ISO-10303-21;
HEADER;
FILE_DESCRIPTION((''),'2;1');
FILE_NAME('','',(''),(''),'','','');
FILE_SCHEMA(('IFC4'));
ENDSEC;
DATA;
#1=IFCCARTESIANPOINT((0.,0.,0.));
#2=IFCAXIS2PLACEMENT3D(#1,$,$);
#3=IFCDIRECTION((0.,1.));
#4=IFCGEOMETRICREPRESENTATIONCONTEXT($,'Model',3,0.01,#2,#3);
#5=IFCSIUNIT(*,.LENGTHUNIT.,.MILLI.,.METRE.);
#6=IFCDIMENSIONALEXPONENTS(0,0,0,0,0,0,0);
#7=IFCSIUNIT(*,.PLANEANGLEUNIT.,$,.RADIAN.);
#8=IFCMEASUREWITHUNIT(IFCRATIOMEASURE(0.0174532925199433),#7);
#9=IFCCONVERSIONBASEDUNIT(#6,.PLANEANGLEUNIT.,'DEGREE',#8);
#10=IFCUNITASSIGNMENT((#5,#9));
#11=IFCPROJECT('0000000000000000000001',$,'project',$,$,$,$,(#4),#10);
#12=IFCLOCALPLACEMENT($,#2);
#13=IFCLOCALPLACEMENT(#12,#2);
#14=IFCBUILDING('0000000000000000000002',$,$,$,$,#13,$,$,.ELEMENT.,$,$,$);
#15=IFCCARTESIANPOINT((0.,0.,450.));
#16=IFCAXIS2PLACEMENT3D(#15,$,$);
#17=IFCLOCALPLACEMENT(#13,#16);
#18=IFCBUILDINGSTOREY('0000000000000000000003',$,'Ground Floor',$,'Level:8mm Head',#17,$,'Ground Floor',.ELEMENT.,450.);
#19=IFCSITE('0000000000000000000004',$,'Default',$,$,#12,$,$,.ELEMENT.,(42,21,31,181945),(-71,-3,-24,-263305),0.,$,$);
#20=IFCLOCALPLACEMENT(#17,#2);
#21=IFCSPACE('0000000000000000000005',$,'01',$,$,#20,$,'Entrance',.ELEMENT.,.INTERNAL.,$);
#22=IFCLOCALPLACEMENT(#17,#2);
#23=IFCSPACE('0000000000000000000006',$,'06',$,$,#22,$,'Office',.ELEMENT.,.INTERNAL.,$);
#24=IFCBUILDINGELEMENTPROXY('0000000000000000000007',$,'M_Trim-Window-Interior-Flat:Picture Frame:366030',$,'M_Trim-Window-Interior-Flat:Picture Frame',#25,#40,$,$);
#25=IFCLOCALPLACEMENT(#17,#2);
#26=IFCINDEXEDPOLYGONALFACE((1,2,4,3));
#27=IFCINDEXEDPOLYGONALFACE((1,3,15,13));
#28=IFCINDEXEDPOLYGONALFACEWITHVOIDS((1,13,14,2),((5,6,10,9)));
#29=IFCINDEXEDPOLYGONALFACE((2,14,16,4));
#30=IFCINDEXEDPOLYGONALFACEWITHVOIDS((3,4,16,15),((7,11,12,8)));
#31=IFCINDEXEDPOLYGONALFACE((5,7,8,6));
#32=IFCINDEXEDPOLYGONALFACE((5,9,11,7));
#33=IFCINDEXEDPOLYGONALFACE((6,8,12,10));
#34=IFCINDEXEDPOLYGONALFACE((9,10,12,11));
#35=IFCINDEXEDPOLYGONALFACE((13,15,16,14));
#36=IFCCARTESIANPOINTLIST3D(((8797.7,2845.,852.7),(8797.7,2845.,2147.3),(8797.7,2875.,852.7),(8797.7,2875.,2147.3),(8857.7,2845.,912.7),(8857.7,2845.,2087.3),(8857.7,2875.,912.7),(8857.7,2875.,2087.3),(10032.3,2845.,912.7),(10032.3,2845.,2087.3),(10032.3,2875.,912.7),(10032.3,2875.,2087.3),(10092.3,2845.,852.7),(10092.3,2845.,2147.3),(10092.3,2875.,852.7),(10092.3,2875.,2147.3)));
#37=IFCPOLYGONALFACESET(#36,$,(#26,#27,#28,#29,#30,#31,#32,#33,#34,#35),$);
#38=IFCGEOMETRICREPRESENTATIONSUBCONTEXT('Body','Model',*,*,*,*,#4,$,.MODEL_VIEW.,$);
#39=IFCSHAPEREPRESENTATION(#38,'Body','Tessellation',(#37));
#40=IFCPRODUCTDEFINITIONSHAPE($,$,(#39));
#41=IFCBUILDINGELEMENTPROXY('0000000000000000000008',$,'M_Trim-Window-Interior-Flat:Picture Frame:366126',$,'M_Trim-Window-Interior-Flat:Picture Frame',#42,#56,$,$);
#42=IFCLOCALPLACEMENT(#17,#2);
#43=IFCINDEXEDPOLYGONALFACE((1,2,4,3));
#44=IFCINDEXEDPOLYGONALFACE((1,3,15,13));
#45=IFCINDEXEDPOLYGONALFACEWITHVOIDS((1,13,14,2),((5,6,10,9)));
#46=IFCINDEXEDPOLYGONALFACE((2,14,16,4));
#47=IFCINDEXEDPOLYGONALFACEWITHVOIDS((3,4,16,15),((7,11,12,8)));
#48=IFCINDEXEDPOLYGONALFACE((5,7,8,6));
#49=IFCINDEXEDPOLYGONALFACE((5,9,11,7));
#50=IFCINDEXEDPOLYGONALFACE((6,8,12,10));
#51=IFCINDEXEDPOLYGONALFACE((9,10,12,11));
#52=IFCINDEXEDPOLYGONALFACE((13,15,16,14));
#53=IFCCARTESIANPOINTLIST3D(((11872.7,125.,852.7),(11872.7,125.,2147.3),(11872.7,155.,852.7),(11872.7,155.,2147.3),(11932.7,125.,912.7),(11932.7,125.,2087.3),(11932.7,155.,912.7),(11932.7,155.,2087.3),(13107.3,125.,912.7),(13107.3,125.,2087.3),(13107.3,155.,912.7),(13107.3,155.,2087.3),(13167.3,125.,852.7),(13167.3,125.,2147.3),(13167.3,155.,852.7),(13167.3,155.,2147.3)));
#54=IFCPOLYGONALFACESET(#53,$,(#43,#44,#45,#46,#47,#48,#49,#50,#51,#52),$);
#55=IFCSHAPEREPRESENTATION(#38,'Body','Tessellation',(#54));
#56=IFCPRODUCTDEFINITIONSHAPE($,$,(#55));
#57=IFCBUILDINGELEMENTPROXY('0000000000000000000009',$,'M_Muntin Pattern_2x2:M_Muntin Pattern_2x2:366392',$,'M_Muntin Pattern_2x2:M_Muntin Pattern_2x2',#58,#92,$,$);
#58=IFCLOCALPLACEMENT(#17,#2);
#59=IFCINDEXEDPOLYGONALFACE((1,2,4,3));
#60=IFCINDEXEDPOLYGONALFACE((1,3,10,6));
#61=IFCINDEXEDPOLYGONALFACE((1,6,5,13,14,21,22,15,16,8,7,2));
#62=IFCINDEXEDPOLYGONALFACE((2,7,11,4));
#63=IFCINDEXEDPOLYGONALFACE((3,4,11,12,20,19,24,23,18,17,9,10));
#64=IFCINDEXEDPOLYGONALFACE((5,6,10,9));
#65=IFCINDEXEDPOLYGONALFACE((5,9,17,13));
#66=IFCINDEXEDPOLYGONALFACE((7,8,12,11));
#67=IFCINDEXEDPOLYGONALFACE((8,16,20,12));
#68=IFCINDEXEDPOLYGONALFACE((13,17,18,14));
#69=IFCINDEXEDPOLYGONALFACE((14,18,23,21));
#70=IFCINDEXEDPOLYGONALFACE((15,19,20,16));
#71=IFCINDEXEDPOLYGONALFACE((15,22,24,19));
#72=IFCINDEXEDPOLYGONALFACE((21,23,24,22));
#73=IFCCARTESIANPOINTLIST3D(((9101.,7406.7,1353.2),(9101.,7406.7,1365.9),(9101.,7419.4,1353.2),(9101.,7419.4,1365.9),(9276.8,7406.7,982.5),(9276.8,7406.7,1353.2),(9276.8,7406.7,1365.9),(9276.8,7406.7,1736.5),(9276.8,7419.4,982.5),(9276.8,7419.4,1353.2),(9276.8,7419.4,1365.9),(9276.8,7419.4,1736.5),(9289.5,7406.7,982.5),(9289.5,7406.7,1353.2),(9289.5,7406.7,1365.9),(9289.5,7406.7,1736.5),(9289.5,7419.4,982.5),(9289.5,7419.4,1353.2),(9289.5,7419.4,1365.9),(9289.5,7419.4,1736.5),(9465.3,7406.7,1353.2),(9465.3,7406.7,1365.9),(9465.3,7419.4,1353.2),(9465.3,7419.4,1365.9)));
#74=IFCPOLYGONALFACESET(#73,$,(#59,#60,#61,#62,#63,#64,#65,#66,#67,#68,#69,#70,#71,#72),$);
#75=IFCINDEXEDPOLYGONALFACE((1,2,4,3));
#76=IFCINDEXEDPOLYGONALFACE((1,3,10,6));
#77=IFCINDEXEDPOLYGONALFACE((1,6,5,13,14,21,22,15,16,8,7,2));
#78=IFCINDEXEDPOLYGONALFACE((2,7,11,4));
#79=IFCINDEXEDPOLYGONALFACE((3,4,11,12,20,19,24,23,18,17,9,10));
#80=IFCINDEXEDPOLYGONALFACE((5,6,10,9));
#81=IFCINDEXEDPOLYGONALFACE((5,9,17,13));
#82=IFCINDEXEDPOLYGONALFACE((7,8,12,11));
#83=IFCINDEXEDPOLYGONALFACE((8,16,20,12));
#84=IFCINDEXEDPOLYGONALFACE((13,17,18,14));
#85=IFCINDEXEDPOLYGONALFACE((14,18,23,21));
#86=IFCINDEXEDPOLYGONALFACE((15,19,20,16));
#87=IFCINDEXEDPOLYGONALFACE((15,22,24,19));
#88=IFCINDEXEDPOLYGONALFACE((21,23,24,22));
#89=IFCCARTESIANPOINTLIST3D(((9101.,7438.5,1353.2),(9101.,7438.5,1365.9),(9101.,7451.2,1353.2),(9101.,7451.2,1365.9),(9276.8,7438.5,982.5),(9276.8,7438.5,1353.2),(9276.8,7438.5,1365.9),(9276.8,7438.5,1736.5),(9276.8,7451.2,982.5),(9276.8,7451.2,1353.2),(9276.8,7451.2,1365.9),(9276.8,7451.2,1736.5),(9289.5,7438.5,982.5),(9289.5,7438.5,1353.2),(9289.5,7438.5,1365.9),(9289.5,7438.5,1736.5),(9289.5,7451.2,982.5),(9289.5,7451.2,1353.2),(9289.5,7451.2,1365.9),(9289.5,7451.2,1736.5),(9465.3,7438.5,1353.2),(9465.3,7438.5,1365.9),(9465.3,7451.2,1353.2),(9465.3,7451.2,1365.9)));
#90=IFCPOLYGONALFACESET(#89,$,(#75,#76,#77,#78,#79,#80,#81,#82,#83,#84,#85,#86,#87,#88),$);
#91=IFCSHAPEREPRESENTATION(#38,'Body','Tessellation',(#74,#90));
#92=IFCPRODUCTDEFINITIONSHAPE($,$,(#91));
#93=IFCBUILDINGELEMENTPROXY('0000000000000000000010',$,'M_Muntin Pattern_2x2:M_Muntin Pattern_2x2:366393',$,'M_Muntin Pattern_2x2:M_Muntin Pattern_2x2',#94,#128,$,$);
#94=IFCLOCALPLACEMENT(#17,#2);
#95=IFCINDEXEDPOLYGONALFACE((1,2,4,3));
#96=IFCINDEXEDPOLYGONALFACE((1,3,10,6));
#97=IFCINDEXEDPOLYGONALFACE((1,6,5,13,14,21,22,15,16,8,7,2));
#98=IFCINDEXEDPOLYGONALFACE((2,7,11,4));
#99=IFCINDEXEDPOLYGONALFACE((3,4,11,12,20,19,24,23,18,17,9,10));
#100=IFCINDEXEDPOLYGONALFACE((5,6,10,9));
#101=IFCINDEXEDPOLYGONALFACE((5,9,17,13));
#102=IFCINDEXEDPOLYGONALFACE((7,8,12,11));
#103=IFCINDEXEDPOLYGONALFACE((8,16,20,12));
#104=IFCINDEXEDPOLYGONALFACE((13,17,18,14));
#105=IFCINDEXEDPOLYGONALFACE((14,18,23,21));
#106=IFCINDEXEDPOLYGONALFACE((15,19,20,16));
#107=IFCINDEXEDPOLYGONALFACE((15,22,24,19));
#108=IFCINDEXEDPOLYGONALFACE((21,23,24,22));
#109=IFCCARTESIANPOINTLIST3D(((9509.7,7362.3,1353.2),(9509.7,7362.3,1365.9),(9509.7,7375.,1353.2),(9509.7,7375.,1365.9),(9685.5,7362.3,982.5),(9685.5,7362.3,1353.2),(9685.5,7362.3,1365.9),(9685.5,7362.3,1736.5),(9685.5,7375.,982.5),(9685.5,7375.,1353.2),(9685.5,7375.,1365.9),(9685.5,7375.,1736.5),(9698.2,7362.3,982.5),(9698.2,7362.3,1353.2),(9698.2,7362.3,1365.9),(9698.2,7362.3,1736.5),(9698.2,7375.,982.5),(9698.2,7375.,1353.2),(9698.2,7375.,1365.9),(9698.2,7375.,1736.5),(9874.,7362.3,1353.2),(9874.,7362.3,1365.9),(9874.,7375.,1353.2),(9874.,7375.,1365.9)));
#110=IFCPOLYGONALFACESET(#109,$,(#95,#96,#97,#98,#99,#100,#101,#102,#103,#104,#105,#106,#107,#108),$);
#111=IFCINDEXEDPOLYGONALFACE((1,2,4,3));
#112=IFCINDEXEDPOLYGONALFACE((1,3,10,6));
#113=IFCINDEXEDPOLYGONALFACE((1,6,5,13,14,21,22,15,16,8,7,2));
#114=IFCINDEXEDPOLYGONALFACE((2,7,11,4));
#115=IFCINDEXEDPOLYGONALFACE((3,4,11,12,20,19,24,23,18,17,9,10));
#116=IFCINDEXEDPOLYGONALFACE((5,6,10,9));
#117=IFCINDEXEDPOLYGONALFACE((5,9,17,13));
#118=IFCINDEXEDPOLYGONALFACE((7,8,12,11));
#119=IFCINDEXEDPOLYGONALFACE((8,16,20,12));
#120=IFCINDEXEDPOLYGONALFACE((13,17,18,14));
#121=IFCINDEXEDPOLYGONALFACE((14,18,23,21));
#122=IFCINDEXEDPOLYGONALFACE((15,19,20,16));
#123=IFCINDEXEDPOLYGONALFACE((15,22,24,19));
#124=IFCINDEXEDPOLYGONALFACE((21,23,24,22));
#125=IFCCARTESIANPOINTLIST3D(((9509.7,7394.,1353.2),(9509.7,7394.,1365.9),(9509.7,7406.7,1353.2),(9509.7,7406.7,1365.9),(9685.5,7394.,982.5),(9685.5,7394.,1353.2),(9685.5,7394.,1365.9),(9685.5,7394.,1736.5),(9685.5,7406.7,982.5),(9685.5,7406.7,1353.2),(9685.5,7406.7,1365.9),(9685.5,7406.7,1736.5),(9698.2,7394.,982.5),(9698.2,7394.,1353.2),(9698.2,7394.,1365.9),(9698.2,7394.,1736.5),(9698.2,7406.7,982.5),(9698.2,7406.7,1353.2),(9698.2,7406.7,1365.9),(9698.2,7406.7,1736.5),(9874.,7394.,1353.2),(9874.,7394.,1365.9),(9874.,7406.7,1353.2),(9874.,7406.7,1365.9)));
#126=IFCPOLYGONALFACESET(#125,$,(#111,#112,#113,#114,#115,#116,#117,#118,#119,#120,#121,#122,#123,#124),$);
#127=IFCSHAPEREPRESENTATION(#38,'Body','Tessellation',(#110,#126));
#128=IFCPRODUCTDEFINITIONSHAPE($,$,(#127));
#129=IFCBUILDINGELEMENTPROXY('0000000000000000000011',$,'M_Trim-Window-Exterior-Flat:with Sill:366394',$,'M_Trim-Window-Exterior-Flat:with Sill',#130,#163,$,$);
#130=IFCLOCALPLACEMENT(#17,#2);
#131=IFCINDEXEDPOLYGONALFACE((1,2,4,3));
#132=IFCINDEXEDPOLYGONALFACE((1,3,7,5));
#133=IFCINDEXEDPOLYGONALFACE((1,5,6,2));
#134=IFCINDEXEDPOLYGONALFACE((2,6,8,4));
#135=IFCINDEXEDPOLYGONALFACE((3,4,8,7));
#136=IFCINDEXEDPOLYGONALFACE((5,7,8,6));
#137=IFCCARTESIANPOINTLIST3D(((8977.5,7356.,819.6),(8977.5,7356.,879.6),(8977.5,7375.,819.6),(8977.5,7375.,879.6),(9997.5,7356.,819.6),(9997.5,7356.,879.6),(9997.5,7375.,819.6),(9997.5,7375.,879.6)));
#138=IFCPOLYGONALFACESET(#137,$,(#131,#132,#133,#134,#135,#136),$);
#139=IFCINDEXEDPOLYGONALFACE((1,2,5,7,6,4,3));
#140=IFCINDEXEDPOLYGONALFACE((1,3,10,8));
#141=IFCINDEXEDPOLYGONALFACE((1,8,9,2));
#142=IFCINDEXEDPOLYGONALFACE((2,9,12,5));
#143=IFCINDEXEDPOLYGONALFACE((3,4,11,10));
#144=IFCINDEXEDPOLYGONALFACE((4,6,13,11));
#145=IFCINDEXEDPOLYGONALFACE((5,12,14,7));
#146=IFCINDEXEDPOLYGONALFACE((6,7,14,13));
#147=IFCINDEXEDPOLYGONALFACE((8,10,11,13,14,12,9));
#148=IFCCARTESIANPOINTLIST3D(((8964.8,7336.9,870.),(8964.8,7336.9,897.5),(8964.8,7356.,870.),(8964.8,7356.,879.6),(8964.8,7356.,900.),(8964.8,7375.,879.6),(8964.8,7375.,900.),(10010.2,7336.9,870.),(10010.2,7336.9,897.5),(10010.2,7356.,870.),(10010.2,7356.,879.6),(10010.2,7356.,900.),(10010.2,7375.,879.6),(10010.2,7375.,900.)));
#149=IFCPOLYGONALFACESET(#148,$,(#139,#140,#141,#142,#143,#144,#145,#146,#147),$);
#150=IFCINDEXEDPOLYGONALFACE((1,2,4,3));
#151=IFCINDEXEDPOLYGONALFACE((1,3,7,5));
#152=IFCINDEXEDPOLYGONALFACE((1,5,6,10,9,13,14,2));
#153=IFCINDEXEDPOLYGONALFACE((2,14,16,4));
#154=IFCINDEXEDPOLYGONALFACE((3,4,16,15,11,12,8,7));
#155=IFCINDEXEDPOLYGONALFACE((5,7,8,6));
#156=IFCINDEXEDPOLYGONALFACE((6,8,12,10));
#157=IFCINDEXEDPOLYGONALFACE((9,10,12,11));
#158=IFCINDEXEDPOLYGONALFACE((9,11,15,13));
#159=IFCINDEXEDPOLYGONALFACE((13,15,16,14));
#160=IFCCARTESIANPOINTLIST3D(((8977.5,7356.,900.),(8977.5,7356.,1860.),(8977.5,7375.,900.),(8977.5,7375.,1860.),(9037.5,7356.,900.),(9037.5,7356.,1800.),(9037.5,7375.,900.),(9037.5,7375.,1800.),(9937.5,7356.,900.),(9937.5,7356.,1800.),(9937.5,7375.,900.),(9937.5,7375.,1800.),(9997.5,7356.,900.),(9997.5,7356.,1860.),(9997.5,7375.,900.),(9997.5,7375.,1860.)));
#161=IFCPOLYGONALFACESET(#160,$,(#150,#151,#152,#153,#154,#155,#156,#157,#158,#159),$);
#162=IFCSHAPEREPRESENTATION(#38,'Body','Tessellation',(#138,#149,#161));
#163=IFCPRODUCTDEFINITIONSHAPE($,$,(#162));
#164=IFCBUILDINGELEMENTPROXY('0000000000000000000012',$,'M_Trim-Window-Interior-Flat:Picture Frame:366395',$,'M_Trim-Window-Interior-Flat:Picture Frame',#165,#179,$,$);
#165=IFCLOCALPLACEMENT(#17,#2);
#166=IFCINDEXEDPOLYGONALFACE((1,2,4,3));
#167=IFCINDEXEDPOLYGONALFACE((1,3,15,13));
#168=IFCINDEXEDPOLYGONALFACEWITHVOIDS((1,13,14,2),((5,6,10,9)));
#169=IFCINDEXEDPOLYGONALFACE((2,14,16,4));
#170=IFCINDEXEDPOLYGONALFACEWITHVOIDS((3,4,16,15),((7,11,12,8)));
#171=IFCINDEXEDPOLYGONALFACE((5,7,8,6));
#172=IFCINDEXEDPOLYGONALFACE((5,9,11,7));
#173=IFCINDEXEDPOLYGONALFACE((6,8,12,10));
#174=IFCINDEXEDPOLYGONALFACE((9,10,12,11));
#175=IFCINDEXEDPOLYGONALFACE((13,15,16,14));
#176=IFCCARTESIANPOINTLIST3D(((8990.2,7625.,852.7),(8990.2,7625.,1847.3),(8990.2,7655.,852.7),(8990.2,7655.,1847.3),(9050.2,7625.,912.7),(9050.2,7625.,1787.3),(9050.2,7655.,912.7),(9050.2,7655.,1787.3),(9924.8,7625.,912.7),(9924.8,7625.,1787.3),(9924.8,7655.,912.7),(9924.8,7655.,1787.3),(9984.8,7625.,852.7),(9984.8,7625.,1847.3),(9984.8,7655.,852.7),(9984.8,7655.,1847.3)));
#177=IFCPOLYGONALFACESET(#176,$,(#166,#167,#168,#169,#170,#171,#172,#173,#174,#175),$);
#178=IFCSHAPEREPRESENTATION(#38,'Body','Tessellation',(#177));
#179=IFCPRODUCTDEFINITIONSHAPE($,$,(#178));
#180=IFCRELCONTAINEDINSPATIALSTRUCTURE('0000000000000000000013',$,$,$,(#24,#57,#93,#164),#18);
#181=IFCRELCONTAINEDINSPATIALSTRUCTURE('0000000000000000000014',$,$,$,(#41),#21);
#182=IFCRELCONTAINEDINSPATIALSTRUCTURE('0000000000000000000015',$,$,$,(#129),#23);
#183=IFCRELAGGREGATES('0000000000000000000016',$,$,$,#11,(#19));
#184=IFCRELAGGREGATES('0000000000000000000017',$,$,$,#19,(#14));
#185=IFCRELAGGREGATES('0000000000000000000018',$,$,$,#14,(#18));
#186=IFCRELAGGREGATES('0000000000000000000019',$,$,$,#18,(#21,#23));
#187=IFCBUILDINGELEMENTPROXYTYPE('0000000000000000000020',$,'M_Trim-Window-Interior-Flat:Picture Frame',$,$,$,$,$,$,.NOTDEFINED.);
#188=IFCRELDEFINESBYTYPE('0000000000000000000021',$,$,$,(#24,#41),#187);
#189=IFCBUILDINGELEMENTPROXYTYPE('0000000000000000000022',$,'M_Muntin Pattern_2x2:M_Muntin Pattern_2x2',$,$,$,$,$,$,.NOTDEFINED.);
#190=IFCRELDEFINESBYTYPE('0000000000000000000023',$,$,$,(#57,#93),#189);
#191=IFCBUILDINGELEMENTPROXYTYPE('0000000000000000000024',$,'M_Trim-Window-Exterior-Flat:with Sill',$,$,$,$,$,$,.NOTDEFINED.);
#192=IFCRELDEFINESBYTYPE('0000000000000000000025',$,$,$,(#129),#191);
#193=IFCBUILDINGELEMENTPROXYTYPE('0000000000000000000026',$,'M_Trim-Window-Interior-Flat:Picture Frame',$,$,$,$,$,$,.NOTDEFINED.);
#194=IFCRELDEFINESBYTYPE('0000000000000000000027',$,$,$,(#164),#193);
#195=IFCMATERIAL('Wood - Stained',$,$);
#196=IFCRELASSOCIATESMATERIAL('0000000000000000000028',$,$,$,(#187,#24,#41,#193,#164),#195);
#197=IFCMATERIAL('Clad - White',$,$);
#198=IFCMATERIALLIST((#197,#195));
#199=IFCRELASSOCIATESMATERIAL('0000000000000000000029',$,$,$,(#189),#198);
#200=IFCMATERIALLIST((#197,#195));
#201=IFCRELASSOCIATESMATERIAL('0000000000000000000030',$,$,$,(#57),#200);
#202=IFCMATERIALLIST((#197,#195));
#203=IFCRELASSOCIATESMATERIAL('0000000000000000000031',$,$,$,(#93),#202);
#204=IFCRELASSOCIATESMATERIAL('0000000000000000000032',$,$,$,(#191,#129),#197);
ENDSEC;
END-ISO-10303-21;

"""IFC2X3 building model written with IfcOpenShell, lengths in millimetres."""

from ifc_helpers import new_model, entity, si_unit, converted_unit, direction, frame, frame_2d, origin, place, context, subcontext, project, spatial, polyline, rectangle, outline, extrude, source, transform, mapped, material, material_list, type_object, type_shapes, element, save


model = new_model("IFC2X3")

# Units and contexts
model_context = context("Model", 3, precision=0.01, world=origin(), true_north=direction((0.0, 1.0)))
body_context = subcontext(model_context, "Body", "Model", "MODEL_VIEW")
ifc_project = project(units=[si_unit("LENGTHUNIT", "METRE", prefix="MILLI"), converted_unit("PLANEANGLEUNIT", "DEGREE", entity("IfcRatioMeasure", 0.0174532925199433), si_unit("PLANEANGLEUNIT", "RADIAN"), dimensions=[0, 0, 0, 0, 0, 0, 0])], contexts=[model_context])

# Site, building, storey
site_placement = place(None, origin())
site = spatial("IfcSite", under=ifc_project, at=site_placement, Name="Default", CompositionType="ELEMENT", RefLatitude=(42, 21, 31, 181945), RefLongitude=(-71, -3, -24, -263305), RefElevation=0.0)
building_placement = place(site_placement, origin())
building = spatial("IfcBuilding", under=site, at=building_placement, CompositionType="ELEMENT")
storey_placement = place(building_placement, frame((0.0, 0.0, 450.0)))
storey = spatial("IfcBuildingStorey", under=building, at=storey_placement, Name="Ground Floor", ObjectType="Level:8mm Head", LongName="Ground Floor", CompositionType="ELEMENT", Elevation=450.0)

# Shared definitions
ifc_material_1 = material(Name="Clad - White")
ifc_material_2 = material(Name="Wood - Stained")

# Building element proxy
building_element_proxy_type_1 = type_object("IfcBuildingElementProxyType", Name="M_Trim-Window-Interior-Flat:Picture Frame", PredefinedType="NOTDEFINED", material=ifc_material_2)
shared_shape_1 = source(origin(), body_context, "Body", "SweptSolid", [
    extrude(outline(polyline([(-647.3, -647.3), (647.3, -647.3), (647.3, 647.3), (-647.3, 647.3), (-647.3, -647.3)]), holes=[polyline([(-587.3, -587.3), (-587.3, 587.3), (587.3, 587.3), (587.3, -587.3), (-587.3, -587.3)])]), frame((0.0, -600.0, 0.0), z_axis=(0.0, 0.0, 1.0), x_axis=(-1.0, 0.0, 0.0)), (0.0, 0.0, 1.0), 30.0),
])
type_shapes(building_element_proxy_type_1, [shared_shape_1])
proxy_1_placement = place(storey_placement, frame((9445.0, 2875.0, 2100.0), z_axis=(0.0, -1.0, 0.0), x_axis=(1.0, 0.0, 0.0)))
element("IfcBuildingElementProxy", 1, at=proxy_1_placement, inside=storey, type_object=building_element_proxy_type_1, material=ifc_material_2, Name="M_Trim-Window-Interior-Flat:Picture Frame:366030", ObjectType="M_Trim-Window-Interior-Flat:Picture Frame", context=body_context, shape_type="MappedRepresentation", body=[
    mapped(shared_shape_1, transform((0.0, 0.0, 0.0), scale=1.0)),
])

# Shared definitions
space_1_placement = place(storey_placement, origin())
space_1 = spatial("IfcSpace", under=storey, at=space_1_placement, Name="01", LongName="Entrance", CompositionType="ELEMENT", InteriorOrExteriorSpace="INTERNAL")

# Building element proxies
proxy_2_placement = place(space_1_placement, frame((12520.0, 125.0, 2100.0), z_axis=(0.0, 1.0, 0.0), x_axis=(-1.0, 0.0, 0.0)))
element("IfcBuildingElementProxy", 2, at=proxy_2_placement, inside=space_1, type_object=building_element_proxy_type_1, material=ifc_material_2, Name="M_Trim-Window-Interior-Flat:Picture Frame:366126", ObjectType="M_Trim-Window-Interior-Flat:Picture Frame", context=body_context, shape_type="MappedRepresentation", body=[
    mapped(shared_shape_1, transform((0.0, 0.0, 0.0), scale=1.0)),
])
ifc_material_list_1 = material_list([ifc_material_1, ifc_material_2])
ifc_material_list_2 = material_list([ifc_material_1, ifc_material_2])
building_element_proxy_type_2 = type_object("IfcBuildingElementProxyType", Name="M_Muntin Pattern_2x2:M_Muntin Pattern_2x2", PredefinedType="NOTDEFINED", material=ifc_material_list_2)
shared_shape_2 = source(origin(), body_context, "Body", "SweptSolid", [
    extrude(outline(polyline([(6.4, -6.4), (377.0, -6.4), (377.0, 6.3), (6.4, 6.3), (6.4, 182.1), (-6.3, 182.1), (-6.3, 6.3), (-377.0, 6.3), (-377.0, -6.4), (-6.3, -6.4), (-6.3, -182.1), (6.4, -182.1), (6.4, -6.4)])), frame((0.0, 9.5, 377.0), z_axis=(0.0, 1.0, 0.0), x_axis=(0.0, 0.0, 1.0)), (0.0, 0.0, 1.0), 12.7),
    extrude(outline(polyline([(6.4, -6.4), (377.0, -6.4), (377.0, 6.3), (6.4, 6.3), (6.4, 182.1), (-6.3, 182.1), (-6.3, 6.3), (-377.0, 6.3), (-377.0, -6.4), (-6.3, -6.4), (-6.3, -182.1), (6.4, -182.1), (6.4, -6.4)])), frame((0.0, -22.2, 377.0), z_axis=(0.0, 1.0, 0.0), x_axis=(0.0, 0.0, 1.0)), (0.0, 0.0, 1.0), 12.7),
])
type_shapes(building_element_proxy_type_2, [shared_shape_2])
proxy_3_placement = place(storey_placement, frame((9283.1, 7429.0, 982.5), z_axis=(0.0, 0.0, 1.0), x_axis=(-1.0, 0.0, 0.0)))
element("IfcBuildingElementProxy", 3, at=proxy_3_placement, inside=storey, type_object=building_element_proxy_type_2, material=ifc_material_list_1, Name="M_Muntin Pattern_2x2:M_Muntin Pattern_2x2:366392", ObjectType="M_Muntin Pattern_2x2:M_Muntin Pattern_2x2", context=body_context, shape_type="MappedRepresentation", body=[
    mapped(shared_shape_2, transform((0.0, 0.0, 0.0), scale=1.0)),
])
ifc_material_list_3 = material_list([ifc_material_1, ifc_material_2])
proxy_4_placement = place(storey_placement, frame((9691.9, 7384.5, 982.5), z_axis=(0.0, 0.0, 1.0), x_axis=(-1.0, 0.0, 0.0)))
element("IfcBuildingElementProxy", 4, at=proxy_4_placement, inside=storey, type_object=building_element_proxy_type_2, material=ifc_material_list_3, Name="M_Muntin Pattern_2x2:M_Muntin Pattern_2x2:366393", ObjectType="M_Muntin Pattern_2x2:M_Muntin Pattern_2x2", context=body_context, shape_type="MappedRepresentation", body=[
    mapped(shared_shape_2, transform((0.0, 0.0, 0.0), scale=1.0)),
])

# Shared definitions
space_2_placement = place(storey_placement, origin())
space_2 = spatial("IfcSpace", under=storey, at=space_2_placement, Name="06", LongName="Office", CompositionType="ELEMENT", InteriorOrExteriorSpace="INTERNAL")

# Building element proxies
building_element_proxy_type_3 = type_object("IfcBuildingElementProxyType", Name="M_Trim-Window-Exterior-Flat:with Sill", PredefinedType="NOTDEFINED", material=ifc_material_1)
shared_shape_3 = source(origin(), body_context, "Body", "SweptSolid", [
    extrude(rectangle(XDim=1020.0, YDim=60.0, at=frame_2d((0.0, 0.0), x_axis=(1.0, 0.0))), frame((0.0, -950.4, 0.0), z_axis=(0.0, 0.0, 1.0), x_axis=(-1.0, 0.0, 0.0)), (0.0, 0.0, 1.0), 19.1),
    extrude(outline(polyline([(-19.0, -15.2), (0.0, -15.2), (0.0, -5.7), (19.0, -5.7), (19.0, 14.8), (0.0, 14.8), (-19.0, 12.3), (-19.0, -15.2)])), frame((-522.7, -914.8, 19.0), z_axis=(1.0, 0.0, 0.0), x_axis=(0.0, 0.0, -1.0)), (0.0, 0.0, 1.0), 1045.4),
    extrude(outline(polyline([(-495.0, -510.0), (465.0, -510.0), (465.0, -450.0), (-435.0, -450.0), (-435.0, 450.0), (465.0, 450.0), (465.0, 510.0), (-495.0, 510.0), (-495.0, -510.0)])), frame((0.0, -435.0, 0.0), z_axis=(0.0, 0.0, 1.0), x_axis=(0.0, -1.0, 0.0)), (0.0, 0.0, 1.0), 19.1),
])
type_shapes(building_element_proxy_type_3, [shared_shape_3])
proxy_5_placement = place(space_2_placement, frame((9487.5, 7375.0, 1800.0), z_axis=(0.0, -1.0, 0.0), x_axis=(1.0, 0.0, 0.0)))
element("IfcBuildingElementProxy", 5, at=proxy_5_placement, inside=space_2, type_object=building_element_proxy_type_3, material=ifc_material_1, Name="M_Trim-Window-Exterior-Flat:with Sill:366394", ObjectType="M_Trim-Window-Exterior-Flat:with Sill", context=body_context, shape_type="MappedRepresentation", body=[
    mapped(shared_shape_3, transform((0.0, 0.0, 0.0), scale=1.0)),
])
building_element_proxy_type_4 = type_object("IfcBuildingElementProxyType", Name="M_Trim-Window-Interior-Flat:Picture Frame", PredefinedType="NOTDEFINED", material=ifc_material_2)
shared_shape_4 = source(origin(), body_context, "Body", "SweptSolid", [
    extrude(outline(polyline([(-497.3, -497.3), (497.3, -497.3), (497.3, 497.3), (-497.3, 497.3), (-497.3, -497.3)]), holes=[polyline([(-437.3, -437.3), (-437.3, 437.3), (437.3, 437.3), (437.3, -437.3), (-437.3, -437.3)])]), frame((0.0, -450.0, 0.0), z_axis=(0.0, 0.0, 1.0), x_axis=(-1.0, 0.0, 0.0)), (0.0, 0.0, 1.0), 30.0),
])
type_shapes(building_element_proxy_type_4, [shared_shape_4])
proxy_6_placement = place(storey_placement, frame((9487.5, 7625.0, 1800.0), z_axis=(0.0, 1.0, 0.0), x_axis=(-1.0, 0.0, 0.0)))
element("IfcBuildingElementProxy", 6, at=proxy_6_placement, inside=storey, type_object=building_element_proxy_type_4, material=ifc_material_2, Name="M_Trim-Window-Interior-Flat:Picture Frame:366395", ObjectType="M_Trim-Window-Interior-Flat:Picture Frame", context=body_context, shape_type="MappedRepresentation", body=[
    mapped(shared_shape_4, transform((0.0, 0.0, 0.0), scale=1.0)),
])

save(model, "model.ifc")
